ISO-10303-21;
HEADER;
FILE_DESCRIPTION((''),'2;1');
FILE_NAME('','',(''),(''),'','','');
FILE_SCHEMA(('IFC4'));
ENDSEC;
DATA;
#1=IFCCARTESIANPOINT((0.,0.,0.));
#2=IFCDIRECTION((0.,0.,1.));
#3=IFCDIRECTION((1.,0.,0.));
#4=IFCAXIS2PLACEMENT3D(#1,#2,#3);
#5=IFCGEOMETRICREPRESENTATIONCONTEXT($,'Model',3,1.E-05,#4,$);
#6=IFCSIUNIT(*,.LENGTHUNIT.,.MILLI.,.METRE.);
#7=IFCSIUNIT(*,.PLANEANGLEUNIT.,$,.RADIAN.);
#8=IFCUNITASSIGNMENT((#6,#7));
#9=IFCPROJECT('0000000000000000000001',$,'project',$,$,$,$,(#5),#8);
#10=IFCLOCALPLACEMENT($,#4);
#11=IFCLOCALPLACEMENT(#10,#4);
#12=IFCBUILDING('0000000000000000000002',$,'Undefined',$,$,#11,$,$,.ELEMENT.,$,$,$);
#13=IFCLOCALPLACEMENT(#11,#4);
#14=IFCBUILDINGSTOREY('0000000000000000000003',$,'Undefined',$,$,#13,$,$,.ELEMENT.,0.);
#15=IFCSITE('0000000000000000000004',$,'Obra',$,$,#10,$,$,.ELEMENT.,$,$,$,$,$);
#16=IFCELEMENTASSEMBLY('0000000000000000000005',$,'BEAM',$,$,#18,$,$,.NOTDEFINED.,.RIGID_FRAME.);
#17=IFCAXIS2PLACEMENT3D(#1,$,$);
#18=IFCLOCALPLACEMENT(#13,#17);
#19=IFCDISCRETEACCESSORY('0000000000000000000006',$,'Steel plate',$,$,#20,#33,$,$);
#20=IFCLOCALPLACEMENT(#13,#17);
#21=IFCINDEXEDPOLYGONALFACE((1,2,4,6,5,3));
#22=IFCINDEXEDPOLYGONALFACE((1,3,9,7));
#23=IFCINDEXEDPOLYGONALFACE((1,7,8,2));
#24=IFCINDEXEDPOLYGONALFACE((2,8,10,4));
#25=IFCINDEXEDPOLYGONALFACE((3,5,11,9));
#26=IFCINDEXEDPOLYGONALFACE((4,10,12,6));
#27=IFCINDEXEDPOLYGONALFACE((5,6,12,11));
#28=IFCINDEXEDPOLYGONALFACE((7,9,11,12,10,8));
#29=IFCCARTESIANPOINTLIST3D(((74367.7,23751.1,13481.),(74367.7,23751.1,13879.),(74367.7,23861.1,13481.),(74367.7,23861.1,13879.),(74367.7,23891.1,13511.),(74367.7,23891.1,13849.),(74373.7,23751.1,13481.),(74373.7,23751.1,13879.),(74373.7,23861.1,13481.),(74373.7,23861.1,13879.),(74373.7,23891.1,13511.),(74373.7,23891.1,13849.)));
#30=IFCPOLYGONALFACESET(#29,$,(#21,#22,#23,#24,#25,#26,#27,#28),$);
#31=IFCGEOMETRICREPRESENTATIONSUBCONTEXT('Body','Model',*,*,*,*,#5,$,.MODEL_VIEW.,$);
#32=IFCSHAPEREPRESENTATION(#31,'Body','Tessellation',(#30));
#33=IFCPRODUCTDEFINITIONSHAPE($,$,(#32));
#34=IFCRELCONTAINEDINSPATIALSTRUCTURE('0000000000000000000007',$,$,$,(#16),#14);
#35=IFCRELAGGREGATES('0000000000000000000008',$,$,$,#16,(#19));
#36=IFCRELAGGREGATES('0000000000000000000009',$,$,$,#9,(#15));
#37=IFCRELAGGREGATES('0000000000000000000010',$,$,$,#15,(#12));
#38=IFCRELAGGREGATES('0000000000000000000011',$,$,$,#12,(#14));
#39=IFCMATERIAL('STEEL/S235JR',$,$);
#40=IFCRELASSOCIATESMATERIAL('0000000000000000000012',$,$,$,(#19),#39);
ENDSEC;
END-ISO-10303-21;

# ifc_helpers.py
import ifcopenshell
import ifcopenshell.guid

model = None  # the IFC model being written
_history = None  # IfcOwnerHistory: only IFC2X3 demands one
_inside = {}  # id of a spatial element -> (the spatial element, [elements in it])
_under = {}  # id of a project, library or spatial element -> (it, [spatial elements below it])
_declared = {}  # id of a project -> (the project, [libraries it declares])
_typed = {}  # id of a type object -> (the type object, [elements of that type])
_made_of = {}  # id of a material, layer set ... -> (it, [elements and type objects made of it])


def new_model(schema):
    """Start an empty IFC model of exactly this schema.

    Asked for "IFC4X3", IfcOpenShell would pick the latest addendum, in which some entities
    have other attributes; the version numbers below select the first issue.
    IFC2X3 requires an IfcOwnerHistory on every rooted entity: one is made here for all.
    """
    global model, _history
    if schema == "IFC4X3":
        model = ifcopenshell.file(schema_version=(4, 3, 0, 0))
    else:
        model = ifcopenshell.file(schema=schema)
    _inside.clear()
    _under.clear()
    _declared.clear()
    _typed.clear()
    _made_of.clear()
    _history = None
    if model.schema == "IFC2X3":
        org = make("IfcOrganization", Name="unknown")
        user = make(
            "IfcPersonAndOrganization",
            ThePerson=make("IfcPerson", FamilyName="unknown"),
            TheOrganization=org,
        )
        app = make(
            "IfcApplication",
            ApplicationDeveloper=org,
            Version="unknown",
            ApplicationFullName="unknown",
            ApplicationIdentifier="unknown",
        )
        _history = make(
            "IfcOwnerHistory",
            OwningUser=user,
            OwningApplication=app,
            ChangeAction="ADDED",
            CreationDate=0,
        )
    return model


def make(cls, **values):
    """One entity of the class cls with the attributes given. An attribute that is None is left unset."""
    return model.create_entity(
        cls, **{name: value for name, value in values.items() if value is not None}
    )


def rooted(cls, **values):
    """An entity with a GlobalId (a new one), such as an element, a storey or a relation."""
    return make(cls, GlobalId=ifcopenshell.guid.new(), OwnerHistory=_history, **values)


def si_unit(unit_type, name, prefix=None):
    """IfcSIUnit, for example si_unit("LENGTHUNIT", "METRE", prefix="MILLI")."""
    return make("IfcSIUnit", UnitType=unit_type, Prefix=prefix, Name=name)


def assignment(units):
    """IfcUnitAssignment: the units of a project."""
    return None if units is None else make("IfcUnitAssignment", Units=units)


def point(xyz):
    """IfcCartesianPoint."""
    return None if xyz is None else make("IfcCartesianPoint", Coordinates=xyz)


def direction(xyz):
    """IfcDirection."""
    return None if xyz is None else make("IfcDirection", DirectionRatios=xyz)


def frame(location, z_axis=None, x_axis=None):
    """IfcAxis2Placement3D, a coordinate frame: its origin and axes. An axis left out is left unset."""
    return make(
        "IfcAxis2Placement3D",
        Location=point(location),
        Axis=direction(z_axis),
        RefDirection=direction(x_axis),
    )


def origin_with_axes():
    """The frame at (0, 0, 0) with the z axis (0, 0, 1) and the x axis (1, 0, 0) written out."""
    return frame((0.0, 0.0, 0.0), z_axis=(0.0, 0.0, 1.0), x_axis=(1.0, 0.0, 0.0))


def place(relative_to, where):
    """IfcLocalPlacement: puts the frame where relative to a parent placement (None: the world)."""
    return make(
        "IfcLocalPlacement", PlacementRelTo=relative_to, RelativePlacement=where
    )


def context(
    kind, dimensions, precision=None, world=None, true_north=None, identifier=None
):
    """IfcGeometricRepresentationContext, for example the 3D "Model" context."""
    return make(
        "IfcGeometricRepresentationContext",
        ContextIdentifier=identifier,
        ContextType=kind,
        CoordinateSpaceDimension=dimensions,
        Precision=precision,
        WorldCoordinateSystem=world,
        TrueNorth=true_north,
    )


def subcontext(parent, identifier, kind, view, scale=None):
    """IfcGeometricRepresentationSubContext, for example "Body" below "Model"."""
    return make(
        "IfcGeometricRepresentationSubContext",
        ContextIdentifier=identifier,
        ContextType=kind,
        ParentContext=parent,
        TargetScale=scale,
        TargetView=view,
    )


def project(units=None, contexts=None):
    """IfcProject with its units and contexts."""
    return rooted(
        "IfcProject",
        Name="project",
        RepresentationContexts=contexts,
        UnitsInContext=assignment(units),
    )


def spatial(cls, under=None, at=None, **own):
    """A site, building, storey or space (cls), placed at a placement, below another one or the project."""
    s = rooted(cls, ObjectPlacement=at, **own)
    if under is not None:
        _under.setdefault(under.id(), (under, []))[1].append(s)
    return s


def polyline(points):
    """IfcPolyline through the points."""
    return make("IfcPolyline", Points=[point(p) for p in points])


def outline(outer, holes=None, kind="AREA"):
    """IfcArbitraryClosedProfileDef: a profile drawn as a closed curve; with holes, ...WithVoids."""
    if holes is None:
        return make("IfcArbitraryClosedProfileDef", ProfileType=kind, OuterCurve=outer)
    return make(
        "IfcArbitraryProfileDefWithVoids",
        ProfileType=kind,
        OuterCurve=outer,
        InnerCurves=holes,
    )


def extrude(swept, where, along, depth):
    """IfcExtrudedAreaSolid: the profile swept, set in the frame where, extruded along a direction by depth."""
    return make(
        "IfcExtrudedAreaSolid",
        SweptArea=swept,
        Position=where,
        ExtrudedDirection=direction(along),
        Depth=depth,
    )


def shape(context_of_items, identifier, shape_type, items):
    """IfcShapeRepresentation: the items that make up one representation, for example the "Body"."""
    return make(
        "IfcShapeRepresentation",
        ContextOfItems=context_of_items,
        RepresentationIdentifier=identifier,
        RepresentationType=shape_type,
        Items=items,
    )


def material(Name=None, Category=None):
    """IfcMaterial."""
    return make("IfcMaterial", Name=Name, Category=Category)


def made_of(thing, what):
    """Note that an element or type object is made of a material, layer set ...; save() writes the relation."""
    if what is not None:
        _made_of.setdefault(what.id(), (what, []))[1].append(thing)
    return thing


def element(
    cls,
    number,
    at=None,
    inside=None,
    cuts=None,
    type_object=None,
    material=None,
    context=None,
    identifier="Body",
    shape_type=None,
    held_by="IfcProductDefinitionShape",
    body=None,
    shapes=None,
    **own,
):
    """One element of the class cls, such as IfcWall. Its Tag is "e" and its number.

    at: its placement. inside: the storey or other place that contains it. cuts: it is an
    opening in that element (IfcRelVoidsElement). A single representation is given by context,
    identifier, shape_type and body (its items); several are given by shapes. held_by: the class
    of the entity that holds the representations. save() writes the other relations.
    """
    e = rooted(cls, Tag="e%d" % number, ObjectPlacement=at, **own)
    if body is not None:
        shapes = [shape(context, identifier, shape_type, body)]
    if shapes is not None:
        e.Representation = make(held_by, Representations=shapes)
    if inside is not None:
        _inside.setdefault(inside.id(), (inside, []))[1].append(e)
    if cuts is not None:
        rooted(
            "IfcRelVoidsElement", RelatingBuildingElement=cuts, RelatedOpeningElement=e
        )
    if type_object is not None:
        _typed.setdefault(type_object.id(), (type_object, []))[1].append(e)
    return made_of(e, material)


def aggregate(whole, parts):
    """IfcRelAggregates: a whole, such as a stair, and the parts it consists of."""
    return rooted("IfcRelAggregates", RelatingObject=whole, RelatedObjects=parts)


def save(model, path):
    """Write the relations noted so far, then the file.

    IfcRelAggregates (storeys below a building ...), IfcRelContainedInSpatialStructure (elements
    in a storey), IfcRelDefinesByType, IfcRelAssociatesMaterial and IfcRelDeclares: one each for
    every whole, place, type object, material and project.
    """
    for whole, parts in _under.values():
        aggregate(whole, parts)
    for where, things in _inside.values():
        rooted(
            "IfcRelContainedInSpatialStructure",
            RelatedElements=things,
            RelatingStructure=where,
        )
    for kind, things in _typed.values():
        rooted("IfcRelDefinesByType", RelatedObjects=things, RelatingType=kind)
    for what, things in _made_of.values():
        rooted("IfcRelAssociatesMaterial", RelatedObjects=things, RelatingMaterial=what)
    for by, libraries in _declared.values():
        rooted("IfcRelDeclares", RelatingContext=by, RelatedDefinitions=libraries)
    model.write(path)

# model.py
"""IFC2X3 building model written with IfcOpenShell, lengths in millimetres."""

from ifc_helpers import new_model, si_unit, frame, origin_with_axes, place, context, subcontext, project, spatial, polyline, outline, extrude, material, element, aggregate, save


model = new_model("IFC2X3")

# Units and contexts
model_context = context("Model", 3, precision=1e-05, world=origin_with_axes())
body_context = subcontext(model_context, "Body", "Model", "MODEL_VIEW")
ifc_project = project(units=[si_unit("LENGTHUNIT", "METRE", prefix="MILLI"), si_unit("PLANEANGLEUNIT", "RADIAN")], contexts=[model_context])

# Site, building, storey
site_placement = place(None, origin_with_axes())
site = spatial("IfcSite", under=ifc_project, at=site_placement, Name="Obra", CompositionType="ELEMENT")
building_placement = place(site_placement, origin_with_axes())
building = spatial("IfcBuilding", under=site, at=building_placement, Name="Undefined", CompositionType="ELEMENT")
storey_placement = place(building_placement, origin_with_axes())
storey = spatial("IfcBuildingStorey", under=building, at=storey_placement, Name="Undefined", CompositionType="ELEMENT", Elevation=0.0)

# Element assembly
assembly_1_placement = place(storey_placement, origin_with_axes())
assembly_1 = element("IfcElementAssembly", 1, at=assembly_1_placement, inside=storey, Name="BEAM", AssemblyPlace="NOTDEFINED", PredefinedType="RIGID_FRAME")
ifc_material_1 = material(Name="STEEL/S235JR")

# Discrete accessory
discrete_accessory_1_placement = place(assembly_1_placement, frame((74370.7, 23891.1, 13481.0), z_axis=(-1.0, 0.0, 0.0), x_axis=(0.0, -1.0, 0.0)))
discrete_accessory_1 = element("IfcDiscreteAccessory", 2, at=discrete_accessory_1_placement, material=ifc_material_1, Name="Steel plate", context=body_context, shape_type="SweptSolid", body=[
    extrude(outline(polyline([(0.0, 30.0), (30.0, 0.0), (140.0, 0.0), (140.0, 398.0), (30.0, 398.0), (0.0, 368.0), (0.0, 30.0)])), frame((0.0, 0.0, -3.0), z_axis=(0.0, 0.0, 1.0), x_axis=(1.0, 0.0, 0.0)), (0.0, 0.0, 1.0), 6.0),
])
aggregate(assembly_1, [discrete_accessory_1])

save(model, "model.ifc")
